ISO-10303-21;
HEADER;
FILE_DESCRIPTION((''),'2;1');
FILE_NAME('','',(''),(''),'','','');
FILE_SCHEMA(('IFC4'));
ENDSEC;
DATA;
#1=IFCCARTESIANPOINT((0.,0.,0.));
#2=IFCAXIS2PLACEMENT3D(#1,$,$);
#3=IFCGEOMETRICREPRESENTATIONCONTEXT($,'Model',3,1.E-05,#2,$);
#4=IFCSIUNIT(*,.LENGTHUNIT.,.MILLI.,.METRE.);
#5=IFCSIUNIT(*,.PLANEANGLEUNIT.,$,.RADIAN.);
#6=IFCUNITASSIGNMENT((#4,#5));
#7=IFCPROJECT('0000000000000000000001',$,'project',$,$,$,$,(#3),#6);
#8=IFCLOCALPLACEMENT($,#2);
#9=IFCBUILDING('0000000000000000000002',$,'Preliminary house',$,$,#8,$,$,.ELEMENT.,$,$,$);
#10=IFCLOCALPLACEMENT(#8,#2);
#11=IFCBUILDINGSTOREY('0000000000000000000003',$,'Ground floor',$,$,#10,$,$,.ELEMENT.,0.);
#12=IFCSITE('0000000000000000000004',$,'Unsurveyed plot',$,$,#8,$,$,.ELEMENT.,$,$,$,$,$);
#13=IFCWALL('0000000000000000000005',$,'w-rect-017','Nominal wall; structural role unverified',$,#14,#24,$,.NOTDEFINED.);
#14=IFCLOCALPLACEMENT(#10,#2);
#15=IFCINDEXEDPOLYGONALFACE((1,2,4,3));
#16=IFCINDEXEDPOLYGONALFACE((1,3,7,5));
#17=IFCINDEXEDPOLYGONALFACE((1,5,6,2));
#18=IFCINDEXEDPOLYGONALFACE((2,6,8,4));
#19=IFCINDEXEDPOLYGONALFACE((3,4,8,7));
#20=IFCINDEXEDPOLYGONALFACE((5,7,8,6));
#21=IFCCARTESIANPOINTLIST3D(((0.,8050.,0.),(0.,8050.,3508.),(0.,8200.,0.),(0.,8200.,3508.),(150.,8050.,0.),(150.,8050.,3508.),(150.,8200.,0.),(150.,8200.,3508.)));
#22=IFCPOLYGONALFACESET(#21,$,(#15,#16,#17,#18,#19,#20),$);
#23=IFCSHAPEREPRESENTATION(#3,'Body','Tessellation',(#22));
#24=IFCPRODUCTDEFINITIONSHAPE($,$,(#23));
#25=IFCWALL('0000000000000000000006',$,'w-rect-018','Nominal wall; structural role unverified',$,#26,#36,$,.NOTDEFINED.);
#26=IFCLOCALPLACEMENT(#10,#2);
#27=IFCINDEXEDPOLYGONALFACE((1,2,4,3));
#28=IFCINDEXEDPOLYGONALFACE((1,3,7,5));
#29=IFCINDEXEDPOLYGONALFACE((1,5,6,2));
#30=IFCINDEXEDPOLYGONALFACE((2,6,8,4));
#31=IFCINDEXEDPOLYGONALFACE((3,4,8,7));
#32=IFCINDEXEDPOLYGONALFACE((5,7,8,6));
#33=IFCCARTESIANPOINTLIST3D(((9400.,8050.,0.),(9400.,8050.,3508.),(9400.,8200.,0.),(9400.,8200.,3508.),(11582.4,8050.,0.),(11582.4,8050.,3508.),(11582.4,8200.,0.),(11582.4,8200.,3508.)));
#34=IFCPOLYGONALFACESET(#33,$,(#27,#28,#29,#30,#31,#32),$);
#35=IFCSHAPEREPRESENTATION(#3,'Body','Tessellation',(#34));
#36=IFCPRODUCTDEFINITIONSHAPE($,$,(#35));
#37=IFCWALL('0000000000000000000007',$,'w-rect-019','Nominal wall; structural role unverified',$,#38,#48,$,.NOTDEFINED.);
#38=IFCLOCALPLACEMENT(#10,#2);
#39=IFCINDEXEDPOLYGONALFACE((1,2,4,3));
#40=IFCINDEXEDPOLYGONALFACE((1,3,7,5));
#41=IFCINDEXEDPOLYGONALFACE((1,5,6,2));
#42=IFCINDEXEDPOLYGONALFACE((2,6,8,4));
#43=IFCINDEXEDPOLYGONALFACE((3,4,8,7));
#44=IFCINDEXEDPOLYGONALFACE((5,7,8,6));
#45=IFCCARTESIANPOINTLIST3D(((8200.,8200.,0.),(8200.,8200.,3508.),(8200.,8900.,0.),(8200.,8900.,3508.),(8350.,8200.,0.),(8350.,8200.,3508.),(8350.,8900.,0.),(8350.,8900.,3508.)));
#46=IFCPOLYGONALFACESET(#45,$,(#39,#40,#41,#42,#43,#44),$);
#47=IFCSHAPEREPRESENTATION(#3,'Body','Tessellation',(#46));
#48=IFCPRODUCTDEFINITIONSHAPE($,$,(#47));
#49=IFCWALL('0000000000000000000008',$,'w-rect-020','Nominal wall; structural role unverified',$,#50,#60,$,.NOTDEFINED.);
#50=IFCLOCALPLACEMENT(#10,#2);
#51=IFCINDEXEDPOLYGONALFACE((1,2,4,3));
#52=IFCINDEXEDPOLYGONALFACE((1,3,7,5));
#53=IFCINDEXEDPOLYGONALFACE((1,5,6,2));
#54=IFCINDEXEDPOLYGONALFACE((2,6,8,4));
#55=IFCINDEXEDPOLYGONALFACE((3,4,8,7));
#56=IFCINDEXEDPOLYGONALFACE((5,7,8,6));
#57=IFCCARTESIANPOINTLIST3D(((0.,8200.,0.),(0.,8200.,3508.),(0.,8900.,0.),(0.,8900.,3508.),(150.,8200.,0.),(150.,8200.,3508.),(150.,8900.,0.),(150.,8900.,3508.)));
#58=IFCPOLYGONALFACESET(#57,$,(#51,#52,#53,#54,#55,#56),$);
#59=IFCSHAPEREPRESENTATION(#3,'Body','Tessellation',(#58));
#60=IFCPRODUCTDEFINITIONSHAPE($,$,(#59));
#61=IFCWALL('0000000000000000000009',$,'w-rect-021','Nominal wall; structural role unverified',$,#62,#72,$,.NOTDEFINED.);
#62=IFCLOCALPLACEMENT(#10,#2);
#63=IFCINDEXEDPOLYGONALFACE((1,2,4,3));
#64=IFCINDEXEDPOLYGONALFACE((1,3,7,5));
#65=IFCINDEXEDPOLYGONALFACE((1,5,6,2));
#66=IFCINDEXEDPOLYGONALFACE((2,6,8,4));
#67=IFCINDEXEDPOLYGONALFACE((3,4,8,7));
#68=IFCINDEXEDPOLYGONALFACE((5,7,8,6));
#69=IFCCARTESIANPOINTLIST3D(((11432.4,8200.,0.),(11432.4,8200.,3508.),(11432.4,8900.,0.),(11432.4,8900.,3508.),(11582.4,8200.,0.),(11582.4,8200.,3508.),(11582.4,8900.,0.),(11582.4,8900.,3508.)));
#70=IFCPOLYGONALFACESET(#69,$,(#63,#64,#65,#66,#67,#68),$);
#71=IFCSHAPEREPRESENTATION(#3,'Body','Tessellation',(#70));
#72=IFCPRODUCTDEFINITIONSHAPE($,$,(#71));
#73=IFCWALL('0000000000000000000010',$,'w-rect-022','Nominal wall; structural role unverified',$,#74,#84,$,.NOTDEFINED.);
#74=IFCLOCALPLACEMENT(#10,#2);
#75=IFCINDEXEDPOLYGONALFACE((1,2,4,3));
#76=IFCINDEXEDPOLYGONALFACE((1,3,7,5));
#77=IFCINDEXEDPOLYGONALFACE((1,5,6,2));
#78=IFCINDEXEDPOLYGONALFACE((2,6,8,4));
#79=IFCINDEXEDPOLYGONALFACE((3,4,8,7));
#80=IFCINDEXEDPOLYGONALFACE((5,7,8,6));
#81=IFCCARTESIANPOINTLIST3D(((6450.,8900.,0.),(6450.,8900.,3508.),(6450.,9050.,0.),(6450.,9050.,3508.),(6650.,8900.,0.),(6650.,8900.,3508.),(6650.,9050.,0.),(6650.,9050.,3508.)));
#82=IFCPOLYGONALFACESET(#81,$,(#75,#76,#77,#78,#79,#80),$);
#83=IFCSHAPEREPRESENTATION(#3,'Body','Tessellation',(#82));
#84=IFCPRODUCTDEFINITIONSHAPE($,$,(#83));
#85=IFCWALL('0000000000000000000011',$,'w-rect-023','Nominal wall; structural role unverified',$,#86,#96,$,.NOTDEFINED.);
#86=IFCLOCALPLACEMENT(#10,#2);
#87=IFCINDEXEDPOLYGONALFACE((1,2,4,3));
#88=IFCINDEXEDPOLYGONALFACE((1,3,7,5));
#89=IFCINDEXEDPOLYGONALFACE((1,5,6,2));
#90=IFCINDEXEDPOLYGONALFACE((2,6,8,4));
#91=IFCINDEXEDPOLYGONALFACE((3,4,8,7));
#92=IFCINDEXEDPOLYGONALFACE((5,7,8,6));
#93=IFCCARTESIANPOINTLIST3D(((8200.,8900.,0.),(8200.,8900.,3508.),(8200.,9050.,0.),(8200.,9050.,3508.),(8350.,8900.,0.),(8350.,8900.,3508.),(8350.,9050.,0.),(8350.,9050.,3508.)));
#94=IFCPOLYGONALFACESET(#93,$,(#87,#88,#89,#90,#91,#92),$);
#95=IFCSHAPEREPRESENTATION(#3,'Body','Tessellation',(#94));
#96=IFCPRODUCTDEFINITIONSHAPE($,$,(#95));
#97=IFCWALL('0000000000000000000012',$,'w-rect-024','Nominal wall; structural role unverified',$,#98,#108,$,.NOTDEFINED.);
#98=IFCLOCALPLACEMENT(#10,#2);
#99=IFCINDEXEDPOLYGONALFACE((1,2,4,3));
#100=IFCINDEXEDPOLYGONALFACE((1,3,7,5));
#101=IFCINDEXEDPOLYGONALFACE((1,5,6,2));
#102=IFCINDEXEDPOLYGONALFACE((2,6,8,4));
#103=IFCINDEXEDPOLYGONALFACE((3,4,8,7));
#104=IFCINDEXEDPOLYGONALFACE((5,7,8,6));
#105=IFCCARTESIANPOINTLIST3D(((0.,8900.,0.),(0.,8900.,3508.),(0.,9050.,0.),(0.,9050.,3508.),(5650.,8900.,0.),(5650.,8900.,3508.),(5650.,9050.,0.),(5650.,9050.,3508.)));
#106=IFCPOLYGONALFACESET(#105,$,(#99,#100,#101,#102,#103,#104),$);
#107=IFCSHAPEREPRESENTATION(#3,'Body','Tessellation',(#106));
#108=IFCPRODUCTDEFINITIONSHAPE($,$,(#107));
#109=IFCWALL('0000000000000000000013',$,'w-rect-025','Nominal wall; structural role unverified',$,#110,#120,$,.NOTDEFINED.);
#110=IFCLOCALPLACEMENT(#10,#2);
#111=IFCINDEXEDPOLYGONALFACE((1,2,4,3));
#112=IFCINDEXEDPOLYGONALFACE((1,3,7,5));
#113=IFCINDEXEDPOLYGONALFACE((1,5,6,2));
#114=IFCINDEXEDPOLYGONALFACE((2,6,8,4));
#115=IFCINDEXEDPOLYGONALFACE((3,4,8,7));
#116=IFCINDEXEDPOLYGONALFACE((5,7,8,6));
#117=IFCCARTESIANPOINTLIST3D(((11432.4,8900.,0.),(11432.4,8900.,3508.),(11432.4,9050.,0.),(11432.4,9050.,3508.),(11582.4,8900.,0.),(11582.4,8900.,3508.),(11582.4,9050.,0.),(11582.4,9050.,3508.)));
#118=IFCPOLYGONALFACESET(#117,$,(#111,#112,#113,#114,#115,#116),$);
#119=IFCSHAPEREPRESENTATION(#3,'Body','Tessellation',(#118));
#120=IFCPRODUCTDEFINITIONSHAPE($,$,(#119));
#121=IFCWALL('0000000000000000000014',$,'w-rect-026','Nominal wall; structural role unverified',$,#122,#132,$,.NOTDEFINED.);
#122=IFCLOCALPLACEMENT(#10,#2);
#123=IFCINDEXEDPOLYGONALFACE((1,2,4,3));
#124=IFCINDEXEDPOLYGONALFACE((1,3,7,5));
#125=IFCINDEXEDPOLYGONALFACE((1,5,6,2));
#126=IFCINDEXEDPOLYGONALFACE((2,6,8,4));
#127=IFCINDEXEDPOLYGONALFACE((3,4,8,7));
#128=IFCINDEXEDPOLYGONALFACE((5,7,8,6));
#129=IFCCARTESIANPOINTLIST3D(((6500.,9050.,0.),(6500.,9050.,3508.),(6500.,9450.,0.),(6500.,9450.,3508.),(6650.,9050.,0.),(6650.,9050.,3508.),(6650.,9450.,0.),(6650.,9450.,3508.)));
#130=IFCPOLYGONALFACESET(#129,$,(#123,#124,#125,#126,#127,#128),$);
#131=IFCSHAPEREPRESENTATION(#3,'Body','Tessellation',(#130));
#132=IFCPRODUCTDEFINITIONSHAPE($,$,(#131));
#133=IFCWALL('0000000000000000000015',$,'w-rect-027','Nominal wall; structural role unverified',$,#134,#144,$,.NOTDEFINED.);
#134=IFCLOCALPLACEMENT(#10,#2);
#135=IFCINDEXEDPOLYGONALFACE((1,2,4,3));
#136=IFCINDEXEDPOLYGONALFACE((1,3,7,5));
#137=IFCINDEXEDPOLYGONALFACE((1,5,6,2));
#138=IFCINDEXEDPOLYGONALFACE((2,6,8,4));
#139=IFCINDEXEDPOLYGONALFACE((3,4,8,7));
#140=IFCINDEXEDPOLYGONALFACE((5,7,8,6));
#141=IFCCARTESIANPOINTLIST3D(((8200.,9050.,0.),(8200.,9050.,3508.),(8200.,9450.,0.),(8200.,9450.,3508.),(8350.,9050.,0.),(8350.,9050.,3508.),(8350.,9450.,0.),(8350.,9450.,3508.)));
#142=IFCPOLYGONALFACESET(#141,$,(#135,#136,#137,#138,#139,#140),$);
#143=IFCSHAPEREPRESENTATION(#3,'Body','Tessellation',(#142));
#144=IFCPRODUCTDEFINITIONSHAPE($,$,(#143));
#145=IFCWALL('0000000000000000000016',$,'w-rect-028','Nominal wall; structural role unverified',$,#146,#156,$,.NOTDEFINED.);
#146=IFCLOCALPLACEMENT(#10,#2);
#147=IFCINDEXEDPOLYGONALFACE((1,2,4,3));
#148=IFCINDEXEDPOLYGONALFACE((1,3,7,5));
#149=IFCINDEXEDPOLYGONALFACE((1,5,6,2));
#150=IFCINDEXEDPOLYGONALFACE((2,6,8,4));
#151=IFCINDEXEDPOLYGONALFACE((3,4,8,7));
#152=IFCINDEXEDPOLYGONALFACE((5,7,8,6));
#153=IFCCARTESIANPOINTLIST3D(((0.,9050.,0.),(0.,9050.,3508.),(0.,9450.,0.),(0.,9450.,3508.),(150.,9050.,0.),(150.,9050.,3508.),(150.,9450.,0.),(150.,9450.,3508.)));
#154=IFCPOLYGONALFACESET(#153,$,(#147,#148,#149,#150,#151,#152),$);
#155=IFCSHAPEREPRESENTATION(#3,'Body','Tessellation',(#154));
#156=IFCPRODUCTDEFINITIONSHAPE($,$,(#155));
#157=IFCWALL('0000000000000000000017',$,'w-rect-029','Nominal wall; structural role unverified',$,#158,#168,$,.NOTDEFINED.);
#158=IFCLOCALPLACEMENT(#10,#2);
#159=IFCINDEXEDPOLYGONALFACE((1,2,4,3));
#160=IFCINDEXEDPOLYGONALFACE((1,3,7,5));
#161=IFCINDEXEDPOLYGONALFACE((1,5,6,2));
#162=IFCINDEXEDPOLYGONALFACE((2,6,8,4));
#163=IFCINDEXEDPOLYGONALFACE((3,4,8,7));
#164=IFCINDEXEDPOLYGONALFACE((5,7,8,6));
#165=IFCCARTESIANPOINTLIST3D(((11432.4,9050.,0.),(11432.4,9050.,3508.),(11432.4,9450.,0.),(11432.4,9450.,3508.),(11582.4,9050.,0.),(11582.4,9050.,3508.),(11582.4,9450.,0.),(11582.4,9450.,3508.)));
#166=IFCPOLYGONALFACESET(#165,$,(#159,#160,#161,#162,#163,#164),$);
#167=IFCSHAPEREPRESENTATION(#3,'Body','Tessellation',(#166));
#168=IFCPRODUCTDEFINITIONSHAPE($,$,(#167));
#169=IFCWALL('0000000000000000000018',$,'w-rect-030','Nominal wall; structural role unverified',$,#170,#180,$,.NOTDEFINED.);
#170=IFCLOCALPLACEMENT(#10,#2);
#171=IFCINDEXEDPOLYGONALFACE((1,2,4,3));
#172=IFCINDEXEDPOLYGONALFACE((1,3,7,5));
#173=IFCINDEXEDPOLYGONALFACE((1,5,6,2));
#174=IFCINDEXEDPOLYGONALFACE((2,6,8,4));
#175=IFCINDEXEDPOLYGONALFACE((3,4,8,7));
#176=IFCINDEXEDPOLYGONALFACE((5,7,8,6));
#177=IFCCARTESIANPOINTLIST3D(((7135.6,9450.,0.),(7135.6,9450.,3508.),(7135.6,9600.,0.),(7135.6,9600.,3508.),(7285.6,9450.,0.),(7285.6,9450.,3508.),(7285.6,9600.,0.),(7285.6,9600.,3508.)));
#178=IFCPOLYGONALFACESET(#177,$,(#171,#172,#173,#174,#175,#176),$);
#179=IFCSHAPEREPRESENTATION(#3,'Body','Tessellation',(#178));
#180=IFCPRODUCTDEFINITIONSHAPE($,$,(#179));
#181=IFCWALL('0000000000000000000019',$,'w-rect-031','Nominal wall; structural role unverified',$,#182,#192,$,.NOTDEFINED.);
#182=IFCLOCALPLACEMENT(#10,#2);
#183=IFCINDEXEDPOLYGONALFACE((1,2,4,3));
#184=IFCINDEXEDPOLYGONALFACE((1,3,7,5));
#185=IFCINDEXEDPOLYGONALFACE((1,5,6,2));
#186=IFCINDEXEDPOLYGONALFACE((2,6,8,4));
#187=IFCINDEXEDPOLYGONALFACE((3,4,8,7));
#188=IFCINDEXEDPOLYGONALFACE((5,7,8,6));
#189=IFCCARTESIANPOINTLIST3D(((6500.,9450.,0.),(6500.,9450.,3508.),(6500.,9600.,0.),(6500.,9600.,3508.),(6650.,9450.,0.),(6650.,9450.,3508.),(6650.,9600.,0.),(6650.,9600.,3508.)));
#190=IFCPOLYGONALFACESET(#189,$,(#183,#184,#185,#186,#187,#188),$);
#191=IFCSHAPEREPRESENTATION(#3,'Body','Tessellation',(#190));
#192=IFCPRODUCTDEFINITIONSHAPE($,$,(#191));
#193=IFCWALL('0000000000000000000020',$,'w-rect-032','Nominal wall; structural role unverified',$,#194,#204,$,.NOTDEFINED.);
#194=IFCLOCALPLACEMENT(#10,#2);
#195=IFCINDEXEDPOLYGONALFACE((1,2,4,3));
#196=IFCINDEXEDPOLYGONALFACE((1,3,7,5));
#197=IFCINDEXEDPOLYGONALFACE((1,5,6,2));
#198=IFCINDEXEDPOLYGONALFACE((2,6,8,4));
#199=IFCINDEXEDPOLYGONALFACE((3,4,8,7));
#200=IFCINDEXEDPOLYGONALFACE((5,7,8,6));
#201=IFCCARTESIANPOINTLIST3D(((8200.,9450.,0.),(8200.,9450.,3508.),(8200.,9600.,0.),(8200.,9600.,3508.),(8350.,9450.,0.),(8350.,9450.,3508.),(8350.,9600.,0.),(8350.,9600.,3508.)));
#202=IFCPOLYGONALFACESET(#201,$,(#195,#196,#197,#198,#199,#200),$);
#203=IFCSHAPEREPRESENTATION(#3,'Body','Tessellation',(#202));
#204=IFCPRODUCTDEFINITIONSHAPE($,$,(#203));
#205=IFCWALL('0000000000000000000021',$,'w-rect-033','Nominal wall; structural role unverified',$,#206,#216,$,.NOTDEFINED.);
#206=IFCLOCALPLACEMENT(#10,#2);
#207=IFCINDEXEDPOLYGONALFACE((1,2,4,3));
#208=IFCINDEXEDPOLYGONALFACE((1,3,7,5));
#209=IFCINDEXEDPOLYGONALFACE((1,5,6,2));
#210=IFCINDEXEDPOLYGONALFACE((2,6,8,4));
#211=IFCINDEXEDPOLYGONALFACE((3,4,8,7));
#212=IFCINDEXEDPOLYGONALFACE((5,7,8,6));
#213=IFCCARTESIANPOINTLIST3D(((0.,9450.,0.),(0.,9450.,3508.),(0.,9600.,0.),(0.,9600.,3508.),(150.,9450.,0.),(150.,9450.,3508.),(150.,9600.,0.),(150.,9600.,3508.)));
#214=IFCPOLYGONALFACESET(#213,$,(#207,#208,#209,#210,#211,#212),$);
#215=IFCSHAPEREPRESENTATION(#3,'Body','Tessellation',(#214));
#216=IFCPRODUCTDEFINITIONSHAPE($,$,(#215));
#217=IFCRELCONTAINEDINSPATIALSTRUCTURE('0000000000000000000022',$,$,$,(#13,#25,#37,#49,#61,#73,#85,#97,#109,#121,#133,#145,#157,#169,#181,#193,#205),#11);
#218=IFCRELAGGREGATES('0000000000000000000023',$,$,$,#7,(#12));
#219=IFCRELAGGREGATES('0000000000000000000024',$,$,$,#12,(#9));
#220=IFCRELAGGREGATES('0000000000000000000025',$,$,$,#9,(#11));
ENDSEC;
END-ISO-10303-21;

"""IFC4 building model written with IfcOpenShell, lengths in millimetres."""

from ifc_helpers import new_model, si_unit, origin, place, context, project, spatial, polyline, outline, extrude, element, save


model = new_model("IFC4")

# Units and contexts
model_context = context("Model", 3, precision=1e-05, world=origin())
ifc_project = project(units=[si_unit("LENGTHUNIT", "METRE", prefix="MILLI"), si_unit("PLANEANGLEUNIT", "RADIAN")], contexts=[model_context])

# Site, building, storey
placement_1 = place(None, origin())
site = spatial("IfcSite", under=ifc_project, at=placement_1, Name="Unsurveyed plot", CompositionType="ELEMENT")
building = spatial("IfcBuilding", under=site, at=placement_1, Name="Preliminary house", CompositionType="ELEMENT")
placement_2 = place(placement_1, origin())
storey = spatial("IfcBuildingStorey", under=building, at=placement_2, Name="Ground floor", CompositionType="ELEMENT", Elevation=0.0)

# Walls
element("IfcWall", 1, at=placement_2, inside=storey, Name="w-rect-017", Description="Nominal wall; structural role unverified", PredefinedType="NOTDEFINED", context=model_context, shape_type="SweptSolid", body=[
    extrude(outline(polyline([(0.0, 8050.0), (150.0, 8050.0), (150.0, 8200.0), (0.0, 8200.0), (0.0, 8050.0)])), origin(), (0.0, 0.0, 1.0), 3508.0),
])
element("IfcWall", 2, at=placement_2, inside=storey, Name="w-rect-018", Description="Nominal wall; structural role unverified", PredefinedType="NOTDEFINED", context=model_context, shape_type="SweptSolid", body=[
    extrude(outline(polyline([(9400.0, 8050.0), (11582.4, 8050.0), (11582.4, 8200.0), (9400.0, 8200.0), (9400.0, 8050.0)])), origin(), (0.0, 0.0, 1.0), 3508.0),
])
element("IfcWall", 3, at=placement_2, inside=storey, Name="w-rect-019", Description="Nominal wall; structural role unverified", PredefinedType="NOTDEFINED", context=model_context, shape_type="SweptSolid", body=[
    extrude(outline(polyline([(8200.0, 8200.0), (8350.0, 8200.0), (8350.0, 8900.0), (8200.0, 8900.0), (8200.0, 8200.0)])), origin(), (0.0, 0.0, 1.0), 3508.0),
])
element("IfcWall", 4, at=placement_2, inside=storey, Name="w-rect-020", Description="Nominal wall; structural role unverified", PredefinedType="NOTDEFINED", context=model_context, shape_type="SweptSolid", body=[
    extrude(outline(polyline([(0.0, 8200.0), (150.0, 8200.0), (150.0, 8900.0), (0.0, 8900.0), (0.0, 8200.0)])), origin(), (0.0, 0.0, 1.0), 3508.0),
])
element("IfcWall", 5, at=placement_2, inside=storey, Name="w-rect-021", Description="Nominal wall; structural role unverified", PredefinedType="NOTDEFINED", context=model_context, shape_type="SweptSolid", body=[
    extrude(outline(polyline([(11432.4, 8200.0), (11582.4, 8200.0), (11582.4, 8900.0), (11432.4, 8900.0), (11432.4, 8200.0)])), origin(), (0.0, 0.0, 1.0), 3508.0),
])
element("IfcWall", 6, at=placement_2, inside=storey, Name="w-rect-022", Description="Nominal wall; structural role unverified", PredefinedType="NOTDEFINED", context=model_context, shape_type="SweptSolid", body=[
    extrude(outline(polyline([(6450.0, 8900.0), (6650.0, 8900.0), (6650.0, 9050.0), (6450.0, 9050.0), (6450.0, 8900.0)])), origin(), (0.0, 0.0, 1.0), 3508.0),
])
element("IfcWall", 7, at=placement_2, inside=storey, Name="w-rect-023", Description="Nominal wall; structural role unverified", PredefinedType="NOTDEFINED", context=model_context, shape_type="SweptSolid", body=[
    extrude(outline(polyline([(8200.0, 8900.0), (8350.0, 8900.0), (8350.0, 9050.0), (8200.0, 9050.0), (8200.0, 8900.0)])), origin(), (0.0, 0.0, 1.0), 3508.0),
])
element("IfcWall", 8, at=placement_2, inside=storey, Name="w-rect-024", Description="Nominal wall; structural role unverified", PredefinedType="NOTDEFINED", context=model_context, shape_type="SweptSolid", body=[
    extrude(outline(polyline([(0.0, 8900.0), (5650.0, 8900.0), (5650.0, 9050.0), (0.0, 9050.0), (0.0, 8900.0)])), origin(), (0.0, 0.0, 1.0), 3508.0),
])
element("IfcWall", 9, at=placement_2, inside=storey, Name="w-rect-025", Description="Nominal wall; structural role unverified", PredefinedType="NOTDEFINED", context=model_context, shape_type="SweptSolid", body=[
    extrude(outline(polyline([(11432.4, 8900.0), (11582.4, 8900.0), (11582.4, 9050.0), (11432.4, 9050.0), (11432.4, 8900.0)])), origin(), (0.0, 0.0, 1.0), 3508.0),
])
element("IfcWall", 10, at=placement_2, inside=storey, Name="w-rect-026", Description="Nominal wall; structural role unverified", PredefinedType="NOTDEFINED", context=model_context, shape_type="SweptSolid", body=[
    extrude(outline(polyline([(6500.0, 9050.0), (6650.0, 9050.0), (6650.0, 9450.0), (6500.0, 9450.0), (6500.0, 9050.0)])), origin(), (0.0, 0.0, 1.0), 3508.0),
])
element("IfcWall", 11, at=placement_2, inside=storey, Name="w-rect-027", Description="Nominal wall; structural role unverified", PredefinedType="NOTDEFINED", context=model_context, shape_type="SweptSolid", body=[
    extrude(outline(polyline([(8200.0, 9050.0), (8350.0, 9050.0), (8350.0, 9450.0), (8200.0, 9450.0), (8200.0, 9050.0)])), origin(), (0.0, 0.0, 1.0), 3508.0),
])
element("IfcWall", 12, at=placement_2, inside=storey, Name="w-rect-028", Description="Nominal wall; structural role unverified", PredefinedType="NOTDEFINED", context=model_context, shape_type="SweptSolid", body=[
    extrude(outline(polyline([(0.0, 9050.0), (150.0, 9050.0), (150.0, 9450.0), (0.0, 9450.0), (0.0, 9050.0)])), origin(), (0.0, 0.0, 1.0), 3508.0),
])
element("IfcWall", 13, at=placement_2, inside=storey, Name="w-rect-029", Description="Nominal wall; structural role unverified", PredefinedType="NOTDEFINED", context=model_context, shape_type="SweptSolid", body=[
    extrude(outline(polyline([(11432.4, 9050.0), (11582.4, 9050.0), (11582.4, 9450.0), (11432.4, 9450.0), (11432.4, 9050.0)])), origin(), (0.0, 0.0, 1.0), 3508.0),
])
element("IfcWall", 14, at=placement_2, inside=storey, Name="w-rect-030", Description="Nominal wall; structural role unverified", PredefinedType="NOTDEFINED", context=model_context, shape_type="SweptSolid", body=[
    extrude(outline(polyline([(7135.6, 9450.0), (7285.6, 9450.0), (7285.6, 9600.0), (7135.6, 9600.0), (7135.6, 9450.0)])), origin(), (0.0, 0.0, 1.0), 3508.0),
])
element("IfcWall", 15, at=placement_2, inside=storey, Name="w-rect-031", Description="Nominal wall; structural role unverified", PredefinedType="NOTDEFINED", context=model_context, shape_type="SweptSolid", body=[
    extrude(outline(polyline([(6500.0, 9450.0), (6650.0, 9450.0), (6650.0, 9600.0), (6500.0, 9600.0), (6500.0, 9450.0)])), origin(), (0.0, 0.0, 1.0), 3508.0),
])
element("IfcWall", 16, at=placement_2, inside=storey, Name="w-rect-032", Description="Nominal wall; structural role unverified", PredefinedType="NOTDEFINED", context=model_context, shape_type="SweptSolid", body=[
    extrude(outline(polyline([(8200.0, 9450.0), (8350.0, 9450.0), (8350.0, 9600.0), (8200.0, 9600.0), (8200.0, 9450.0)])), origin(), (0.0, 0.0, 1.0), 3508.0),
])
element("IfcWall", 17, at=placement_2, inside=storey, Name="w-rect-033", Description="Nominal wall; structural role unverified", PredefinedType="NOTDEFINED", context=model_context, shape_type="SweptSolid", body=[
    extrude(outline(polyline([(0.0, 9450.0), (150.0, 9450.0), (150.0, 9600.0), (0.0, 9600.0), (0.0, 9450.0)])), origin(), (0.0, 0.0, 1.0), 3508.0),
])

save(model, "model.ifc")
